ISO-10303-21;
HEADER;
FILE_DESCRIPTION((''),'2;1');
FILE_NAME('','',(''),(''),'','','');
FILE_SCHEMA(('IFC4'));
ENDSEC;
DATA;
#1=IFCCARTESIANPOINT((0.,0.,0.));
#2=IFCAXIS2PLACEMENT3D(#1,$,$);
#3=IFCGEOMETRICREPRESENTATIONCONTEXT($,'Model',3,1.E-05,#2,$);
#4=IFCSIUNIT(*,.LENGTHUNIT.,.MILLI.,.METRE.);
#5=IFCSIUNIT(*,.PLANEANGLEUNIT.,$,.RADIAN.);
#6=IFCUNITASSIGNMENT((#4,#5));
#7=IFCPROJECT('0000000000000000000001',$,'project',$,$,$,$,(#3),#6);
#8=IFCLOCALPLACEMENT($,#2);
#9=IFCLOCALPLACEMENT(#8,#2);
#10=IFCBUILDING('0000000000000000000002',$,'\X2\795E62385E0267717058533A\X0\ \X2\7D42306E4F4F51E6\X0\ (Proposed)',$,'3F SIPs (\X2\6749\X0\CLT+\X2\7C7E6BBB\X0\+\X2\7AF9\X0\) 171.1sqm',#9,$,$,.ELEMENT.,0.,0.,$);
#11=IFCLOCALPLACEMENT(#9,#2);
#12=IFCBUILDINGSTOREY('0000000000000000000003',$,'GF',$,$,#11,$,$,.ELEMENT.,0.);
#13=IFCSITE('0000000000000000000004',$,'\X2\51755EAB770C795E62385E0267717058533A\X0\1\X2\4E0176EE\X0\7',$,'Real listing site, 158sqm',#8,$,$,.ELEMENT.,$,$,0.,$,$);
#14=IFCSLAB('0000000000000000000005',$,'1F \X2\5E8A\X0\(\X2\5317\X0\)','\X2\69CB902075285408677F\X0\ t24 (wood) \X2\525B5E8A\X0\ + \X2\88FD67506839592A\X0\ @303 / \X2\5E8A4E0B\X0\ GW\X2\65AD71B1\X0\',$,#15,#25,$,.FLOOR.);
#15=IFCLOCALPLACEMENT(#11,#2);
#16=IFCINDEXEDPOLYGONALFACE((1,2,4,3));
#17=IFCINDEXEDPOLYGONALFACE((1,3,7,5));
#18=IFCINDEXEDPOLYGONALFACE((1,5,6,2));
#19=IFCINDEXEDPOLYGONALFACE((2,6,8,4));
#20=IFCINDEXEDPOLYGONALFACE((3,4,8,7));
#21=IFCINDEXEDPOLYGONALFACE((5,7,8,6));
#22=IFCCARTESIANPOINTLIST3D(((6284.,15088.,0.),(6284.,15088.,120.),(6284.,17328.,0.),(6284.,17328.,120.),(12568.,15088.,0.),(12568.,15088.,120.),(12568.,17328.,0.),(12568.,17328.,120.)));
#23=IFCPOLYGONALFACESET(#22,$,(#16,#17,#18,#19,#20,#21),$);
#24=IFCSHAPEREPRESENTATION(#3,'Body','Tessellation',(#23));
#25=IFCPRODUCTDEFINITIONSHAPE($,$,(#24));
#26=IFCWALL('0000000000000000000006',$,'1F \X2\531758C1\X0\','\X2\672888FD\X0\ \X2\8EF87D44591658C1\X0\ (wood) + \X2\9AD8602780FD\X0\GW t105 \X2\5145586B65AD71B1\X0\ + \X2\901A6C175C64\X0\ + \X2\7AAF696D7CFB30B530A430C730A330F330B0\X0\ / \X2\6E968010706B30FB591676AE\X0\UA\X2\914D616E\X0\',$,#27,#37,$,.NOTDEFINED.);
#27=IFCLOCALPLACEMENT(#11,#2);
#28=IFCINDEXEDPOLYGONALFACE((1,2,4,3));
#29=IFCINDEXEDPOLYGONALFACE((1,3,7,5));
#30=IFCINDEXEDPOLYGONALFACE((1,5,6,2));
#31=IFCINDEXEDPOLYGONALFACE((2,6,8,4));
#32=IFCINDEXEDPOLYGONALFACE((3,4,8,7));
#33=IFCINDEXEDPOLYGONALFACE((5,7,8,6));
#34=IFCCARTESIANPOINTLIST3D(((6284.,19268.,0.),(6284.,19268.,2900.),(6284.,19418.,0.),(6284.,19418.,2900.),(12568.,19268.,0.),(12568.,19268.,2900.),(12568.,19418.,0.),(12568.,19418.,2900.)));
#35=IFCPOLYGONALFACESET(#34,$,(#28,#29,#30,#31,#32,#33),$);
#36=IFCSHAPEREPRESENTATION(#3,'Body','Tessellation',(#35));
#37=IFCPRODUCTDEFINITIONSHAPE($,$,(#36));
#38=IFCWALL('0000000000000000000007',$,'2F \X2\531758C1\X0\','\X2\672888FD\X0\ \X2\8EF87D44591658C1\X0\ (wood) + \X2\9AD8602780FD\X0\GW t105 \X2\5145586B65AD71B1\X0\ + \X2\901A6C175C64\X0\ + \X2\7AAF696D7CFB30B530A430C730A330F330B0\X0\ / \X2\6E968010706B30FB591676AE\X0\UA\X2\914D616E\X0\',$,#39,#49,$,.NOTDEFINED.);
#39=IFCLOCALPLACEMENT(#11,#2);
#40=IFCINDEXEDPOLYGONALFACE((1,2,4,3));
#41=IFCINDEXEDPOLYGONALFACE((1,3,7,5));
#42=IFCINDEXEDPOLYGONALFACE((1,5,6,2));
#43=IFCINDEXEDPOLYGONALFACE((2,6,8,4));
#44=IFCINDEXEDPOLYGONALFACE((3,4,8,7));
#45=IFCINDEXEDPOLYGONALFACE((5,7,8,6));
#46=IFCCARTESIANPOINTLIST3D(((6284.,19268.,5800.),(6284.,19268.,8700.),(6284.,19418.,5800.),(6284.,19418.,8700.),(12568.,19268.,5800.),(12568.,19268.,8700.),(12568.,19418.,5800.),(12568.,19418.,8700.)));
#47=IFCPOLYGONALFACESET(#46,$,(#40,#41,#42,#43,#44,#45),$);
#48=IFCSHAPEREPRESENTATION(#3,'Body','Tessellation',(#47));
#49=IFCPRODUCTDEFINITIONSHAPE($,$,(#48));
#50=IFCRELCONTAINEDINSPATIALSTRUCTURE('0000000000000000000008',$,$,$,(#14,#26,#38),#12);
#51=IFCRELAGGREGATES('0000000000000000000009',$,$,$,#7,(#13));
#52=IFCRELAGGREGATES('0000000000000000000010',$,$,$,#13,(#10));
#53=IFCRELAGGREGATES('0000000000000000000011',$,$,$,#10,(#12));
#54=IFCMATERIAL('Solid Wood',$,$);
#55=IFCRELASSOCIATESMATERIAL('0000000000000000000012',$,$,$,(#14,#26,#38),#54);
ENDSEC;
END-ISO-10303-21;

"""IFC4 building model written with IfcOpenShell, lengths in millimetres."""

from ifc_helpers import new_model, si_unit, frame, frame_2d, origin, place, context, project, spatial, rectangle, extrude, material, element, save


model = new_model("IFC4")

# Units and contexts
model_context = context("Model", 3, precision=1e-05, world=origin())
ifc_project = project(units=[si_unit("LENGTHUNIT", "METRE", prefix="MILLI"), si_unit("PLANEANGLEUNIT", "RADIAN")], contexts=[model_context])

# Site, building, storey
site_placement = place(None, origin())
site = spatial("IfcSite", under=ifc_project, at=site_placement, Name="兵庫県神戸市東灘区1丁目7", ObjectType="Real listing site, 158sqm", CompositionType="ELEMENT", RefElevation=0.0)
building_placement = place(site_placement, origin())
building = spatial("IfcBuilding", under=site, at=building_placement, Name="神戸市東灘区 終の住処 (Proposed)", ObjectType="3F SIPs (杉CLT+籾殻+竹) 171.1sqm", CompositionType="ELEMENT", ElevationOfRefHeight=0.0, ElevationOfTerrain=0.0)
storey_placement = place(building_placement, origin())
storey = spatial("IfcBuildingStorey", under=building, at=storey_placement, Name="GF", CompositionType="ELEMENT", Elevation=0.0)

# Slab
ifc_material_1 = material(Name="Solid Wood")
slab_1_placement = place(storey_placement, frame((3142.0, 7544.0, 0.0)))
element("IfcSlab", 1, at=slab_1_placement, inside=storey, material=ifc_material_1, Name="1F 床(北)", Description="構造用合板 t24 (wood) 剛床 + 製材根太 @303 / 床下 GW断熱", PredefinedType="FLOOR", context=model_context, shape_type="SweptSolid", body=[
    extrude(rectangle(XDim=6284.0, YDim=2240.0, at=frame_2d((3142.0, 1120.0))), frame((3142.0, 7544.0, 0.0)), (0.0, 0.0, 1.0), 120.0),
])

# Wall
wall_1_placement = place(storey_placement, frame((3142.0, 9634.0, 0.0)))
element("IfcWall", 2, at=wall_1_placement, inside=storey, material=ifc_material_1, Name="1F 北壁", Description="木製 軸組外壁 (wood) + 高性能GW t105 充填断熱 + 通気層 + 窯業系サイディング / 準耐火・外皮UA配慮", PredefinedType="NOTDEFINED", context=model_context, shape_type="SweptSolid", body=[
    extrude(rectangle(XDim=6284.0, YDim=150.0, at=frame_2d((3142.0, 75.0))), frame((3142.0, 9634.0, 0.0)), (0.0, 0.0, 1.0), 2900.0),
])

# Wall
wall_2_placement = place(storey_placement, frame((3142.0, 9634.0, 2900.0)))
element("IfcWall", 3, at=wall_2_placement, inside=storey, material=ifc_material_1, Name="2F 北壁", Description="木製 軸組外壁 (wood) + 高性能GW t105 充填断熱 + 通気層 + 窯業系サイディング / 準耐火・外皮UA配慮", PredefinedType="NOTDEFINED", context=model_context, shape_type="SweptSolid", body=[
    extrude(rectangle(XDim=6284.0, YDim=150.0, at=frame_2d((3142.0, 75.0))), frame((3142.0, 9634.0, 2900.0)), (0.0, 0.0, 1.0), 2900.0),
])

save(model, "model.ifc")
